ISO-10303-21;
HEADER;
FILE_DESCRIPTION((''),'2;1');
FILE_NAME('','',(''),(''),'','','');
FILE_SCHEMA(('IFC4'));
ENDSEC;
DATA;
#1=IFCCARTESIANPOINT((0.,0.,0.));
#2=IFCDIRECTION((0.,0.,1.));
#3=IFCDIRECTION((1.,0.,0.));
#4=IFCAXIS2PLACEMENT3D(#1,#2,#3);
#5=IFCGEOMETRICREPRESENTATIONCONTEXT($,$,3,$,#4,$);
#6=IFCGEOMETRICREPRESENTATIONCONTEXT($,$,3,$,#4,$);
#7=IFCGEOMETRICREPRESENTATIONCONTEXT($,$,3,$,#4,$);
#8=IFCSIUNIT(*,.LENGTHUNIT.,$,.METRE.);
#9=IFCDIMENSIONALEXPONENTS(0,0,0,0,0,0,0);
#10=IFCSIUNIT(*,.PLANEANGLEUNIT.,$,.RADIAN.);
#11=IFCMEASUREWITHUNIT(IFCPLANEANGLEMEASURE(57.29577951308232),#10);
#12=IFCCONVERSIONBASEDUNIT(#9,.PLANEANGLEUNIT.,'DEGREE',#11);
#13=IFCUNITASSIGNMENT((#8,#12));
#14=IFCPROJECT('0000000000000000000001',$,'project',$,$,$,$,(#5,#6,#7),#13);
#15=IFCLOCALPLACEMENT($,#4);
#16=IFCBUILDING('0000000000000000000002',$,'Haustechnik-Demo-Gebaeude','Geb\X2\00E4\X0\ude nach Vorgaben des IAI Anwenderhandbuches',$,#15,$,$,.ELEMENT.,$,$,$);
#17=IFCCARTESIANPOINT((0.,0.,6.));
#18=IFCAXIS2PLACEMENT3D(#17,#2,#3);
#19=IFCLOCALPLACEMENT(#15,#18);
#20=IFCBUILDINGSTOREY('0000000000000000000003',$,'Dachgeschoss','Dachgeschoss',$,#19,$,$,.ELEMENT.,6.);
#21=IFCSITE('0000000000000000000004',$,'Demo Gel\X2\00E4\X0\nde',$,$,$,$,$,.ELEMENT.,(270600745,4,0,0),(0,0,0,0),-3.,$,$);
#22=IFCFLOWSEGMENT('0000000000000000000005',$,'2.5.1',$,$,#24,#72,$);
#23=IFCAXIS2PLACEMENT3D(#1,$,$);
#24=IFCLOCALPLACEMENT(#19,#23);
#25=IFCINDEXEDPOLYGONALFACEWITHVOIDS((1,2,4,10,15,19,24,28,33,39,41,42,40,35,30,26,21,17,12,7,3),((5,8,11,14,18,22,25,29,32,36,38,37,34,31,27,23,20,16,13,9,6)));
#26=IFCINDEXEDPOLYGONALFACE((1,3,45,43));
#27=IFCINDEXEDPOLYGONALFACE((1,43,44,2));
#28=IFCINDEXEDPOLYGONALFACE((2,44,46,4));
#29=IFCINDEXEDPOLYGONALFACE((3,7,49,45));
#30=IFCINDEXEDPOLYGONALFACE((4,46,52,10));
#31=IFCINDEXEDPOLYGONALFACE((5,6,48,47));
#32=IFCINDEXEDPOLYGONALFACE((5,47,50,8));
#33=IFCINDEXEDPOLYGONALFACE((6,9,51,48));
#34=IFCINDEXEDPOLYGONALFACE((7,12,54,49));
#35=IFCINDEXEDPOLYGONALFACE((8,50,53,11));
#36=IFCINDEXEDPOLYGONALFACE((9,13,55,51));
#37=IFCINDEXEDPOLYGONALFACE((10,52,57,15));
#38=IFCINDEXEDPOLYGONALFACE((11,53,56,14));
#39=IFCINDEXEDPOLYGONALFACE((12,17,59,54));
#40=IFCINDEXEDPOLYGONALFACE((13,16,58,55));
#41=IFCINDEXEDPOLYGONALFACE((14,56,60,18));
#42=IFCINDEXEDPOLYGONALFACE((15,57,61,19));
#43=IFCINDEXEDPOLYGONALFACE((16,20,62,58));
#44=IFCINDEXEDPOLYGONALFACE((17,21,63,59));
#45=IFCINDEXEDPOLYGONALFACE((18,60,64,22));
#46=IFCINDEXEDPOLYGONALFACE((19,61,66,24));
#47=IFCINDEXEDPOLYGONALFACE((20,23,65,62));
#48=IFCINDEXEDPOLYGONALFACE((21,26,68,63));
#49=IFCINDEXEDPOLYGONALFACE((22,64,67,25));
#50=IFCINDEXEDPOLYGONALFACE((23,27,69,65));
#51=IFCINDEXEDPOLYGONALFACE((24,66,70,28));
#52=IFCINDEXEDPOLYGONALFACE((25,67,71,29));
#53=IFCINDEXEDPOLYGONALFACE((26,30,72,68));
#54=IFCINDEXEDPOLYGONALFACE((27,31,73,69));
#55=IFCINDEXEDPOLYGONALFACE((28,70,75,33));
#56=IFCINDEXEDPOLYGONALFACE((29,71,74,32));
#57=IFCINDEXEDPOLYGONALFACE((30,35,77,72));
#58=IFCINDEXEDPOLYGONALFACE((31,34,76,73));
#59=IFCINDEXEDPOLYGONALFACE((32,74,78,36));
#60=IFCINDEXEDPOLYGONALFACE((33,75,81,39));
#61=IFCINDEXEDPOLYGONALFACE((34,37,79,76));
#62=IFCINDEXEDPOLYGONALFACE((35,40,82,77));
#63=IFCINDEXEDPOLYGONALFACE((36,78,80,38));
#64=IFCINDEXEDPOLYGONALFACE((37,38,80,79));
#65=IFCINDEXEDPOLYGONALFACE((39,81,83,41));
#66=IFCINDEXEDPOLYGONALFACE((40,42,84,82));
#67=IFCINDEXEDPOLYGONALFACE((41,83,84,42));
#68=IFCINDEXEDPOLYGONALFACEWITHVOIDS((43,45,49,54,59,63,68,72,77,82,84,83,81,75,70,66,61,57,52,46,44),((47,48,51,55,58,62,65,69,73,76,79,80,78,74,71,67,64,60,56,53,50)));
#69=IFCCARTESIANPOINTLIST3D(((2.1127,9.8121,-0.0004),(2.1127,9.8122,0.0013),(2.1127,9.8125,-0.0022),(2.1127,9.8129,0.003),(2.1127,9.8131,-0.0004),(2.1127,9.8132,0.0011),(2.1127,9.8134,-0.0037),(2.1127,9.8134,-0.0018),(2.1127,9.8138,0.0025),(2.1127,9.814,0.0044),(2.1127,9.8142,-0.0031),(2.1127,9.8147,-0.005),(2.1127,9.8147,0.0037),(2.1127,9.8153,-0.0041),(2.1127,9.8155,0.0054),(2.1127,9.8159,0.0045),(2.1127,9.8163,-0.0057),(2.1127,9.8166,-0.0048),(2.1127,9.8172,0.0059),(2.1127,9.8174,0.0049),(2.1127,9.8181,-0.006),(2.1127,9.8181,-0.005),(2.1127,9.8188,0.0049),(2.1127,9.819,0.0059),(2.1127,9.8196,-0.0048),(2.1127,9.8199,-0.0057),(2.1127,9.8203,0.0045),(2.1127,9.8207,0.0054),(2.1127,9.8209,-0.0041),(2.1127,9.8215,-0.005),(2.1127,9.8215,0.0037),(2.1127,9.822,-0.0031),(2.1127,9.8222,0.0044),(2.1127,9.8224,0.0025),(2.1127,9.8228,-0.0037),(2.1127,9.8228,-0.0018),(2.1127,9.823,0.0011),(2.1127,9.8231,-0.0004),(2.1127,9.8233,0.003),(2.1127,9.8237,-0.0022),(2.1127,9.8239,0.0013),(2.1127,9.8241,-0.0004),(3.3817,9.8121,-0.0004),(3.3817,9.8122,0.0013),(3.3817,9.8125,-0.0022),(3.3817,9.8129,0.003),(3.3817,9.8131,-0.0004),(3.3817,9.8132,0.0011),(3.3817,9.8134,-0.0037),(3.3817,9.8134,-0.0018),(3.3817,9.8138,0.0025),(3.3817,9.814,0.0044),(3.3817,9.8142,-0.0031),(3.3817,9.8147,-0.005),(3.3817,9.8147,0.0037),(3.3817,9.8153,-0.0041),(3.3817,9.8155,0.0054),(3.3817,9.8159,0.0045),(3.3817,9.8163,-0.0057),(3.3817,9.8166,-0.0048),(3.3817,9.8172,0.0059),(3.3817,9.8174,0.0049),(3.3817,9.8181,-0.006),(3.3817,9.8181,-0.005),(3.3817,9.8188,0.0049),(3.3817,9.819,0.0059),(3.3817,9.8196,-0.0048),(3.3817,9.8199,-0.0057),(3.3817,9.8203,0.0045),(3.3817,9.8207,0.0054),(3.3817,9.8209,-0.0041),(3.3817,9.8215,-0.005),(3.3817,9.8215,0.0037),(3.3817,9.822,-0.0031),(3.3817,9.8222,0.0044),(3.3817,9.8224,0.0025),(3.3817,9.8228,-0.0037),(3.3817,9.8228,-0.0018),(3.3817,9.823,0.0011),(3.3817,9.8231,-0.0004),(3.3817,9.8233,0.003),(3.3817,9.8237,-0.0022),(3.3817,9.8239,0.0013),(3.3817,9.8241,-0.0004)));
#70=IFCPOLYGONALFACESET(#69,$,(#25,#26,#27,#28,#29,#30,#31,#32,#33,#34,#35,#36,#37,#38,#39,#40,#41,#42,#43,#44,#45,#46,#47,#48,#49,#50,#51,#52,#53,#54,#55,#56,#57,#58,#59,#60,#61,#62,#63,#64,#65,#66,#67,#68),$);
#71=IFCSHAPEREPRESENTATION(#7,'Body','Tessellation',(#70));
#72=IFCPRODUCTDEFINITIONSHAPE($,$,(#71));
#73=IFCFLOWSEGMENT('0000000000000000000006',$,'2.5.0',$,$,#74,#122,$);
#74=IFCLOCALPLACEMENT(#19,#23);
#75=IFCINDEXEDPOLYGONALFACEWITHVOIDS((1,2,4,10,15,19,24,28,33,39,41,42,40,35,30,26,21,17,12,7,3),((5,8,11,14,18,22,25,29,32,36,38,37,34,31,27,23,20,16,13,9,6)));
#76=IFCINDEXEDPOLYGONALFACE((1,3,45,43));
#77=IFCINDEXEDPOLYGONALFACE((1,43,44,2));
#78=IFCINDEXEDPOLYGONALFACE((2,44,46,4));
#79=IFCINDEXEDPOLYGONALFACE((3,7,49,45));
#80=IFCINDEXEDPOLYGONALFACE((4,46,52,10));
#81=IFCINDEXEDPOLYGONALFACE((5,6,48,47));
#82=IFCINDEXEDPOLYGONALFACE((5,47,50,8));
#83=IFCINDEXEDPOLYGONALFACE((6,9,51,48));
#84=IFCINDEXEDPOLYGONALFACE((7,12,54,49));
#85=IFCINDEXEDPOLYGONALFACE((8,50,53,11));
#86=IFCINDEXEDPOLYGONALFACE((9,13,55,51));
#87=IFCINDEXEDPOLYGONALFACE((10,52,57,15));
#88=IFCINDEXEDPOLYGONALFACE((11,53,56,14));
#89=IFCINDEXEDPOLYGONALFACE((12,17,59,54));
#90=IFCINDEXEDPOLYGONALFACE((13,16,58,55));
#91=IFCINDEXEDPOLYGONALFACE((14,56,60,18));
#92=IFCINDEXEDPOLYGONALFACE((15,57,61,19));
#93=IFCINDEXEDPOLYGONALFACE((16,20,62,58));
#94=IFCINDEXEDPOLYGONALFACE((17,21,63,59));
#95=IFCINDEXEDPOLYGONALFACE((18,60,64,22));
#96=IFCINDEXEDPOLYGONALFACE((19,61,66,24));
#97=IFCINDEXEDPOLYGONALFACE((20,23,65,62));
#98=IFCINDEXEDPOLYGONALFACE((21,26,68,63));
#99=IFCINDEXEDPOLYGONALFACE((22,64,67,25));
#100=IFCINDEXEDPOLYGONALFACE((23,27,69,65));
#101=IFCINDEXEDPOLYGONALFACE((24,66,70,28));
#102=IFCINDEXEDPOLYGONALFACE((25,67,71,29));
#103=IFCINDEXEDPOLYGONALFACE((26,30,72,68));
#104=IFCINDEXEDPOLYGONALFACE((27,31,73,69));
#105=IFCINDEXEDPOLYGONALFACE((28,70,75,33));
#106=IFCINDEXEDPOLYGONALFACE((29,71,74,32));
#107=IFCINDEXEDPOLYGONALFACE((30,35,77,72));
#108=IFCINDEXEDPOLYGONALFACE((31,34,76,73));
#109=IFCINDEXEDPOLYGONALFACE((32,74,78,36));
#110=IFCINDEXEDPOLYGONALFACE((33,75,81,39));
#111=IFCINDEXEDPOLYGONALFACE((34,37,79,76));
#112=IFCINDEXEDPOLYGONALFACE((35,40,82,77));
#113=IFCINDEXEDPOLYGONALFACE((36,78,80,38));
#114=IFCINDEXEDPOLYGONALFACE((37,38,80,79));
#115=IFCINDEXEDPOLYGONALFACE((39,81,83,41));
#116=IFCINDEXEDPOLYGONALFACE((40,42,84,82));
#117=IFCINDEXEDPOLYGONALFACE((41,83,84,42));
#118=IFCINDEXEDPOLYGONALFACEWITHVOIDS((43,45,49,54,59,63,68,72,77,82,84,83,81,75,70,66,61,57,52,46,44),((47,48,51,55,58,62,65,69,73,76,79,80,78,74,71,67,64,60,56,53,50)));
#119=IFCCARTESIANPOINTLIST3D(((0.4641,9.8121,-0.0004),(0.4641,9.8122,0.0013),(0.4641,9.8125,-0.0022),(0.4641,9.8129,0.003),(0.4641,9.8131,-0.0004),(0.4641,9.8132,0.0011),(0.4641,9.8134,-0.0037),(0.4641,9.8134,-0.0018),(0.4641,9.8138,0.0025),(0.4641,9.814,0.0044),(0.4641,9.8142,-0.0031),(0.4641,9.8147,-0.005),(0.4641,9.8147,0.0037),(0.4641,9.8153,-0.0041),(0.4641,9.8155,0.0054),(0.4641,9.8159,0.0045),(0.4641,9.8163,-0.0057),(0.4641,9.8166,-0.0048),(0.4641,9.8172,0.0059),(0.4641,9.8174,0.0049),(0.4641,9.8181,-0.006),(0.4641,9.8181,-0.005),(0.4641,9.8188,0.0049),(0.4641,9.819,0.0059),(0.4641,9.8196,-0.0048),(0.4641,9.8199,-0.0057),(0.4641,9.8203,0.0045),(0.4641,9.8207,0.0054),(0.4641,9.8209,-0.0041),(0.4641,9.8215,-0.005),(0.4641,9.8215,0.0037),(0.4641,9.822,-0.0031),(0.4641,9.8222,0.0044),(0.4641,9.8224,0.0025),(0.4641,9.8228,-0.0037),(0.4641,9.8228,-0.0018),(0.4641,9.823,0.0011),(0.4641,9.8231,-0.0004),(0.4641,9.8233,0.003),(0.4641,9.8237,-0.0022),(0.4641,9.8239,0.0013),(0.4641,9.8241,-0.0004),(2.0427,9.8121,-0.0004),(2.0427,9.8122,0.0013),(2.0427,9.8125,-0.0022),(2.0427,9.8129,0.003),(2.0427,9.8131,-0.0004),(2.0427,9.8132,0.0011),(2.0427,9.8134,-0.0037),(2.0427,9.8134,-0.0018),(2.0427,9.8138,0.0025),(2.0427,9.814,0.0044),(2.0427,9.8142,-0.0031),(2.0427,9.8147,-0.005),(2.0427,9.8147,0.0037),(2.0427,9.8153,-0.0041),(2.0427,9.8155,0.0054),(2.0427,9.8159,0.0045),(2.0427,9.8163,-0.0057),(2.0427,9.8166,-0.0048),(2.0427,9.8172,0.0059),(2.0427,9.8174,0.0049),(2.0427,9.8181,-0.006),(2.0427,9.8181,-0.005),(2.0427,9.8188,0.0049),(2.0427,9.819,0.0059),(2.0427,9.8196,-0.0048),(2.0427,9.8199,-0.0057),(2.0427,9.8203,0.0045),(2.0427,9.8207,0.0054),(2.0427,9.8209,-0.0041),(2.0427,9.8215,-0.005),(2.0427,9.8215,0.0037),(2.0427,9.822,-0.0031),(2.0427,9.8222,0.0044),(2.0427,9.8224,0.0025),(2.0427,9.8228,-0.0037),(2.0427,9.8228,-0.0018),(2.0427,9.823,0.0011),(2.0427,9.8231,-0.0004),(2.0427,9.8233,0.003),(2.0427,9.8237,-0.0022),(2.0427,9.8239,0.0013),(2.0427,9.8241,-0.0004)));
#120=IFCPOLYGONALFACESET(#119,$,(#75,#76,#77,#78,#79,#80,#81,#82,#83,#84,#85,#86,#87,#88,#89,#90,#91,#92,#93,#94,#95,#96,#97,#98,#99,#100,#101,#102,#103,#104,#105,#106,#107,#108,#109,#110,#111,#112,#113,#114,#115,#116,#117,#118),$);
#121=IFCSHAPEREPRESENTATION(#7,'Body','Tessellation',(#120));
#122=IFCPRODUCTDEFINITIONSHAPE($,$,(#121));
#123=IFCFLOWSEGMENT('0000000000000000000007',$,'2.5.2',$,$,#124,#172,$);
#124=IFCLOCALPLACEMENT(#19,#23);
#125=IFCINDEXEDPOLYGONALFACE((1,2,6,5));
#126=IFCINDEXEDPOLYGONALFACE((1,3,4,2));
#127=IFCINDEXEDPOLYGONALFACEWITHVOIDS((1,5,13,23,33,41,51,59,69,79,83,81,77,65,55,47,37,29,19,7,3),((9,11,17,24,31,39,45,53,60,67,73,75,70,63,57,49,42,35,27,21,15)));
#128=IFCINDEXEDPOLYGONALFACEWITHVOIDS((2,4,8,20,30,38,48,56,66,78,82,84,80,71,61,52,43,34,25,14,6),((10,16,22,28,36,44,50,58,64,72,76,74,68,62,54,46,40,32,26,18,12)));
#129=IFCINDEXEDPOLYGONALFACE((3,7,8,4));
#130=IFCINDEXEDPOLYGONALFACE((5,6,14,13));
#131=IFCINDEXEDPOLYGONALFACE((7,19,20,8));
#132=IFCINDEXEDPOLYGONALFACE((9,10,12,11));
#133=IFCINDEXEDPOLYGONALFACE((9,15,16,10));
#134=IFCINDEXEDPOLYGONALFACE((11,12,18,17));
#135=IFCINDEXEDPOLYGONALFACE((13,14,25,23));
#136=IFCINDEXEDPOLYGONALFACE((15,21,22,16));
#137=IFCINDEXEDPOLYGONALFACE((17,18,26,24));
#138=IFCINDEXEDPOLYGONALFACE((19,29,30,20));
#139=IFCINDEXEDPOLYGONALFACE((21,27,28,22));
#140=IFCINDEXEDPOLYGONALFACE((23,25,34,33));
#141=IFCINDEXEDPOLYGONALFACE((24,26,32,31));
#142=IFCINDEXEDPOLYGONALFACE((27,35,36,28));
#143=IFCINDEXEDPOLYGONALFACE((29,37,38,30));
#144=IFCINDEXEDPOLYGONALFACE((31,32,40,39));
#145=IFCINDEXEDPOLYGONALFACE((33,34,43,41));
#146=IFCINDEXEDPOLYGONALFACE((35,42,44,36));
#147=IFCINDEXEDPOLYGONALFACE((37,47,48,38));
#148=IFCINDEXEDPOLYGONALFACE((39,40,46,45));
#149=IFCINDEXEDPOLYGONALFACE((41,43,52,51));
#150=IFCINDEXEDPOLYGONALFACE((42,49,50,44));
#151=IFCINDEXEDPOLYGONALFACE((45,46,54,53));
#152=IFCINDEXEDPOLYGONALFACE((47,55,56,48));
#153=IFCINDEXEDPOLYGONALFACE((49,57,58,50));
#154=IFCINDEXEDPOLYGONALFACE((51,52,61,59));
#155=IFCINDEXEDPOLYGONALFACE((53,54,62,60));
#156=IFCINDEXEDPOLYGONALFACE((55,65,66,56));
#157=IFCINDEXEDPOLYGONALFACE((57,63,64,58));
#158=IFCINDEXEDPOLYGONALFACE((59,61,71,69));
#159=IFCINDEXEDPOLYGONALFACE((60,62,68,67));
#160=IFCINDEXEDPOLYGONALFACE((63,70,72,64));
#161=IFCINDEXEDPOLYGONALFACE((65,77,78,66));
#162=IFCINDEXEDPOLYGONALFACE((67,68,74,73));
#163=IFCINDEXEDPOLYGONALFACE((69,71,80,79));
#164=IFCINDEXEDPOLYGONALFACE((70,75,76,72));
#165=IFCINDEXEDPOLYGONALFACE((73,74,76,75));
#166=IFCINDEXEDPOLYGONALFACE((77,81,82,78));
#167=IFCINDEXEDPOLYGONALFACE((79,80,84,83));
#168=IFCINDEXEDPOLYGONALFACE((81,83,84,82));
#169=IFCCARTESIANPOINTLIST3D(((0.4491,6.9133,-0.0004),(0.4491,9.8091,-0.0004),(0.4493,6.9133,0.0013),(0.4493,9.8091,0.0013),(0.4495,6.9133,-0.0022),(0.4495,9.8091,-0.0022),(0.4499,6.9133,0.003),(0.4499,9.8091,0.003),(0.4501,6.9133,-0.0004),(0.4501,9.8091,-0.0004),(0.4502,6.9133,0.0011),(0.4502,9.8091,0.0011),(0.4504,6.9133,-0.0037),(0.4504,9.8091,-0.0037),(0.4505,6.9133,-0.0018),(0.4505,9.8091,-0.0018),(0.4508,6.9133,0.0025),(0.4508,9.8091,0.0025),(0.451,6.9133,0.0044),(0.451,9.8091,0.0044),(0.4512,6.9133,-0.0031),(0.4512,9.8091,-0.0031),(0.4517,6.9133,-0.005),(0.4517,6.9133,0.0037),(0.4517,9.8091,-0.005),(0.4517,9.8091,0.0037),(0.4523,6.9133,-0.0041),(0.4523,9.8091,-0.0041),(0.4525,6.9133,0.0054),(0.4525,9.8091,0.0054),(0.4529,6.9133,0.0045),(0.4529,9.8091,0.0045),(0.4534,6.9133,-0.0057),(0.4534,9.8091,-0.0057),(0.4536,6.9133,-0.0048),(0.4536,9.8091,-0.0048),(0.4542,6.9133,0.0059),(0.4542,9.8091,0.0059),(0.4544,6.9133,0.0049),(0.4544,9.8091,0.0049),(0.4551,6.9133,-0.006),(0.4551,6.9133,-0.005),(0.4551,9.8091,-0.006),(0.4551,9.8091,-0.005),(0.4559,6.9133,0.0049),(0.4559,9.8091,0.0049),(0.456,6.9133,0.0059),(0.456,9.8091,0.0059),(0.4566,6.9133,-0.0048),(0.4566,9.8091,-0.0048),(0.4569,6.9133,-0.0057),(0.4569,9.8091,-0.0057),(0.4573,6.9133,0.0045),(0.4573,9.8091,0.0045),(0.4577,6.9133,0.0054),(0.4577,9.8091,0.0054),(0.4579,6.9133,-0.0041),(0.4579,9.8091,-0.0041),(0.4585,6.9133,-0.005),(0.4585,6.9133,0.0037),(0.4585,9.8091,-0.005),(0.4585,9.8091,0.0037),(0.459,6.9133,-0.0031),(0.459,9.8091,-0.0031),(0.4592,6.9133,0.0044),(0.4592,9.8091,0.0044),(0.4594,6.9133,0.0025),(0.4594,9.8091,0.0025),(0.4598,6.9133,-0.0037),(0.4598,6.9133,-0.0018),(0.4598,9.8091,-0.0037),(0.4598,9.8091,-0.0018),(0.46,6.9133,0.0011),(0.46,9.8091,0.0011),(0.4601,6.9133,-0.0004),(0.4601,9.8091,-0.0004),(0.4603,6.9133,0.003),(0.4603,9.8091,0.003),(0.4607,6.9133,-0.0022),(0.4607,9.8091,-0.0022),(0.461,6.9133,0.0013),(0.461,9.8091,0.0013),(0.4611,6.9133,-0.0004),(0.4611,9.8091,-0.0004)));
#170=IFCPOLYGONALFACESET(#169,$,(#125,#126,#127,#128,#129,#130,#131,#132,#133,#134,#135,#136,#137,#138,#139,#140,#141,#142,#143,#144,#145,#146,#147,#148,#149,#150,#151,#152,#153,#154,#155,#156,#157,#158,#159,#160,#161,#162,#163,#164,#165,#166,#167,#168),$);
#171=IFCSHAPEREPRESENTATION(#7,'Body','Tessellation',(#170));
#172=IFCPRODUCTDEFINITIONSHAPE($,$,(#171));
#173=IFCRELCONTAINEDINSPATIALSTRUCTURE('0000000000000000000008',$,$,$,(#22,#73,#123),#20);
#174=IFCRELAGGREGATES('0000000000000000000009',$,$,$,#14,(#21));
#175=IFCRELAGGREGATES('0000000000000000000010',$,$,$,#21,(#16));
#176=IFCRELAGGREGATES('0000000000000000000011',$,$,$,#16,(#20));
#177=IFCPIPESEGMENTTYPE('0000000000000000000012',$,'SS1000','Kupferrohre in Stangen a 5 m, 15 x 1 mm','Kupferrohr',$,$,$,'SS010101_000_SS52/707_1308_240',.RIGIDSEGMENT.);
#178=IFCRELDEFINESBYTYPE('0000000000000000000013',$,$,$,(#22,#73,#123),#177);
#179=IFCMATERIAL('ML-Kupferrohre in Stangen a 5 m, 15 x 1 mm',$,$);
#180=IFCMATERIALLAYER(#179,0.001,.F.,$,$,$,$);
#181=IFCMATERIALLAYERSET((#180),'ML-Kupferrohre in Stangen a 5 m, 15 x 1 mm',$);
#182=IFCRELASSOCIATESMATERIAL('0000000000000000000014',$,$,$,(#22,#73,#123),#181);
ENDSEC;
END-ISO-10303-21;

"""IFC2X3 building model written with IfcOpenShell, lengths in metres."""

from ifc_helpers import new_model, entity, si_unit, converted_unit, frame, origin_with_axes, origin_2d_with_axis, place, context, project, spatial, hollow_circle, extrude, material, layer, layer_set, layer_usage, type_object, element, save


model = new_model("IFC2X3")

# Units and contexts
context_of_model_1 = context(None, 3, world=origin_with_axes())
context_of_model_2 = context(None, 3, world=origin_with_axes())
context_of_model_3 = context(None, 3, world=origin_with_axes())
ifc_project = project(units=[si_unit("LENGTHUNIT", "METRE"), converted_unit("PLANEANGLEUNIT", "DEGREE", entity("IfcPlaneAngleMeasure", 57.29577951308232), si_unit("PLANEANGLEUNIT", "RADIAN"), dimensions=[0, 0, 0, 0, 0, 0, 0])], contexts=[context_of_model_1, context_of_model_2, context_of_model_3])

# Site, building, storey
site = spatial("IfcSite", under=ifc_project, Name="Demo Gelände", CompositionType="ELEMENT", RefLatitude=(270600745, 4, 0, 0), RefLongitude=(0, 0, 0, 0), RefElevation=-3.0)
building_placement = place(None, origin_with_axes())
building = spatial("IfcBuilding", under=site, at=building_placement, Name="Haustechnik-Demo-Gebaeude", Description="Gebäude nach Vorgaben des IAI Anwenderhandbuches", CompositionType="ELEMENT")
storey_placement = place(building_placement, frame((0.0, 0.0, 6.0), z_axis=(0.0, 0.0, 1.0), x_axis=(1.0, 0.0, 0.0)))
storey = spatial("IfcBuildingStorey", under=building, at=storey_placement, Name="Dachgeschoss", Description="Dachgeschoss", CompositionType="ELEMENT", Elevation=6.0)

# Flow segments
ifc_material = material(Name="ML-Kupferrohre in Stangen a 5 m, 15 x 1 mm")
ifc_layer = layer(ifc_material, 0.001, ventilated=False)
ifc_layer_set = layer_set([ifc_layer], Name="ML-Kupferrohre in Stangen a 5 m, 15 x 1 mm")
ifc_layer_usage = layer_usage(ifc_layer_set, "AXIS2", "POSITIVE", 0.0)
pipe_segment_type_1 = type_object("IfcPipeSegmentType", Name="SS1000", Description="Kupferrohre in Stangen a 5 m, 15 x 1 mm", ApplicableOccurrence="Kupferrohr", ElementType="SS010101_000_SS52/707_1308_240", PredefinedType="RIGIDSEGMENT")
flow_segment_1_placement = place(storey_placement, frame((3.3817, 9.8181, 0.0), z_axis=(-1.0, 0.0, 0.0), x_axis=(0.0, 0.0, -1.0)))
element("IfcFlowSegment", 1, at=flow_segment_1_placement, inside=storey, type_object=pipe_segment_type_1, material=ifc_layer_usage, Name="2.5.1", context=context_of_model_3, shape_type="SweptSolid", body=[
    extrude(hollow_circle(Radius=0.006, WallThickness=0.001, at=origin_2d_with_axis()), origin_with_axes(), (0.0, 0.0, 1.0), 1.2689),
])
flow_segment_2_placement = place(storey_placement, frame((2.0427, 9.8181, 0.0), z_axis=(-1.0, 0.0, 0.0), x_axis=(0.0, 0.0, -1.0)))
element("IfcFlowSegment", 2, at=flow_segment_2_placement, inside=storey, type_object=pipe_segment_type_1, material=ifc_layer_usage, Name="2.5.0", context=context_of_model_3, shape_type="SweptSolid", body=[
    extrude(hollow_circle(Radius=0.006, WallThickness=0.001, at=origin_2d_with_axis()), origin_with_axes(), (0.0, 0.0, 1.0), 1.5786),
])
flow_segment_3_placement = place(storey_placement, frame((0.4551, 9.8091, 0.0), z_axis=(0.0, -1.0, 0.0), x_axis=(0.0, 0.0, -1.0)))
element("IfcFlowSegment", 3, at=flow_segment_3_placement, inside=storey, type_object=pipe_segment_type_1, material=ifc_layer_usage, Name="2.5.2", context=context_of_model_3, shape_type="SweptSolid", body=[
    extrude(hollow_circle(Radius=0.006, WallThickness=0.001, at=origin_2d_with_axis()), origin_with_axes(), (0.0, 0.0, 1.0), 2.8958),
])

save(model, "model.ifc")
